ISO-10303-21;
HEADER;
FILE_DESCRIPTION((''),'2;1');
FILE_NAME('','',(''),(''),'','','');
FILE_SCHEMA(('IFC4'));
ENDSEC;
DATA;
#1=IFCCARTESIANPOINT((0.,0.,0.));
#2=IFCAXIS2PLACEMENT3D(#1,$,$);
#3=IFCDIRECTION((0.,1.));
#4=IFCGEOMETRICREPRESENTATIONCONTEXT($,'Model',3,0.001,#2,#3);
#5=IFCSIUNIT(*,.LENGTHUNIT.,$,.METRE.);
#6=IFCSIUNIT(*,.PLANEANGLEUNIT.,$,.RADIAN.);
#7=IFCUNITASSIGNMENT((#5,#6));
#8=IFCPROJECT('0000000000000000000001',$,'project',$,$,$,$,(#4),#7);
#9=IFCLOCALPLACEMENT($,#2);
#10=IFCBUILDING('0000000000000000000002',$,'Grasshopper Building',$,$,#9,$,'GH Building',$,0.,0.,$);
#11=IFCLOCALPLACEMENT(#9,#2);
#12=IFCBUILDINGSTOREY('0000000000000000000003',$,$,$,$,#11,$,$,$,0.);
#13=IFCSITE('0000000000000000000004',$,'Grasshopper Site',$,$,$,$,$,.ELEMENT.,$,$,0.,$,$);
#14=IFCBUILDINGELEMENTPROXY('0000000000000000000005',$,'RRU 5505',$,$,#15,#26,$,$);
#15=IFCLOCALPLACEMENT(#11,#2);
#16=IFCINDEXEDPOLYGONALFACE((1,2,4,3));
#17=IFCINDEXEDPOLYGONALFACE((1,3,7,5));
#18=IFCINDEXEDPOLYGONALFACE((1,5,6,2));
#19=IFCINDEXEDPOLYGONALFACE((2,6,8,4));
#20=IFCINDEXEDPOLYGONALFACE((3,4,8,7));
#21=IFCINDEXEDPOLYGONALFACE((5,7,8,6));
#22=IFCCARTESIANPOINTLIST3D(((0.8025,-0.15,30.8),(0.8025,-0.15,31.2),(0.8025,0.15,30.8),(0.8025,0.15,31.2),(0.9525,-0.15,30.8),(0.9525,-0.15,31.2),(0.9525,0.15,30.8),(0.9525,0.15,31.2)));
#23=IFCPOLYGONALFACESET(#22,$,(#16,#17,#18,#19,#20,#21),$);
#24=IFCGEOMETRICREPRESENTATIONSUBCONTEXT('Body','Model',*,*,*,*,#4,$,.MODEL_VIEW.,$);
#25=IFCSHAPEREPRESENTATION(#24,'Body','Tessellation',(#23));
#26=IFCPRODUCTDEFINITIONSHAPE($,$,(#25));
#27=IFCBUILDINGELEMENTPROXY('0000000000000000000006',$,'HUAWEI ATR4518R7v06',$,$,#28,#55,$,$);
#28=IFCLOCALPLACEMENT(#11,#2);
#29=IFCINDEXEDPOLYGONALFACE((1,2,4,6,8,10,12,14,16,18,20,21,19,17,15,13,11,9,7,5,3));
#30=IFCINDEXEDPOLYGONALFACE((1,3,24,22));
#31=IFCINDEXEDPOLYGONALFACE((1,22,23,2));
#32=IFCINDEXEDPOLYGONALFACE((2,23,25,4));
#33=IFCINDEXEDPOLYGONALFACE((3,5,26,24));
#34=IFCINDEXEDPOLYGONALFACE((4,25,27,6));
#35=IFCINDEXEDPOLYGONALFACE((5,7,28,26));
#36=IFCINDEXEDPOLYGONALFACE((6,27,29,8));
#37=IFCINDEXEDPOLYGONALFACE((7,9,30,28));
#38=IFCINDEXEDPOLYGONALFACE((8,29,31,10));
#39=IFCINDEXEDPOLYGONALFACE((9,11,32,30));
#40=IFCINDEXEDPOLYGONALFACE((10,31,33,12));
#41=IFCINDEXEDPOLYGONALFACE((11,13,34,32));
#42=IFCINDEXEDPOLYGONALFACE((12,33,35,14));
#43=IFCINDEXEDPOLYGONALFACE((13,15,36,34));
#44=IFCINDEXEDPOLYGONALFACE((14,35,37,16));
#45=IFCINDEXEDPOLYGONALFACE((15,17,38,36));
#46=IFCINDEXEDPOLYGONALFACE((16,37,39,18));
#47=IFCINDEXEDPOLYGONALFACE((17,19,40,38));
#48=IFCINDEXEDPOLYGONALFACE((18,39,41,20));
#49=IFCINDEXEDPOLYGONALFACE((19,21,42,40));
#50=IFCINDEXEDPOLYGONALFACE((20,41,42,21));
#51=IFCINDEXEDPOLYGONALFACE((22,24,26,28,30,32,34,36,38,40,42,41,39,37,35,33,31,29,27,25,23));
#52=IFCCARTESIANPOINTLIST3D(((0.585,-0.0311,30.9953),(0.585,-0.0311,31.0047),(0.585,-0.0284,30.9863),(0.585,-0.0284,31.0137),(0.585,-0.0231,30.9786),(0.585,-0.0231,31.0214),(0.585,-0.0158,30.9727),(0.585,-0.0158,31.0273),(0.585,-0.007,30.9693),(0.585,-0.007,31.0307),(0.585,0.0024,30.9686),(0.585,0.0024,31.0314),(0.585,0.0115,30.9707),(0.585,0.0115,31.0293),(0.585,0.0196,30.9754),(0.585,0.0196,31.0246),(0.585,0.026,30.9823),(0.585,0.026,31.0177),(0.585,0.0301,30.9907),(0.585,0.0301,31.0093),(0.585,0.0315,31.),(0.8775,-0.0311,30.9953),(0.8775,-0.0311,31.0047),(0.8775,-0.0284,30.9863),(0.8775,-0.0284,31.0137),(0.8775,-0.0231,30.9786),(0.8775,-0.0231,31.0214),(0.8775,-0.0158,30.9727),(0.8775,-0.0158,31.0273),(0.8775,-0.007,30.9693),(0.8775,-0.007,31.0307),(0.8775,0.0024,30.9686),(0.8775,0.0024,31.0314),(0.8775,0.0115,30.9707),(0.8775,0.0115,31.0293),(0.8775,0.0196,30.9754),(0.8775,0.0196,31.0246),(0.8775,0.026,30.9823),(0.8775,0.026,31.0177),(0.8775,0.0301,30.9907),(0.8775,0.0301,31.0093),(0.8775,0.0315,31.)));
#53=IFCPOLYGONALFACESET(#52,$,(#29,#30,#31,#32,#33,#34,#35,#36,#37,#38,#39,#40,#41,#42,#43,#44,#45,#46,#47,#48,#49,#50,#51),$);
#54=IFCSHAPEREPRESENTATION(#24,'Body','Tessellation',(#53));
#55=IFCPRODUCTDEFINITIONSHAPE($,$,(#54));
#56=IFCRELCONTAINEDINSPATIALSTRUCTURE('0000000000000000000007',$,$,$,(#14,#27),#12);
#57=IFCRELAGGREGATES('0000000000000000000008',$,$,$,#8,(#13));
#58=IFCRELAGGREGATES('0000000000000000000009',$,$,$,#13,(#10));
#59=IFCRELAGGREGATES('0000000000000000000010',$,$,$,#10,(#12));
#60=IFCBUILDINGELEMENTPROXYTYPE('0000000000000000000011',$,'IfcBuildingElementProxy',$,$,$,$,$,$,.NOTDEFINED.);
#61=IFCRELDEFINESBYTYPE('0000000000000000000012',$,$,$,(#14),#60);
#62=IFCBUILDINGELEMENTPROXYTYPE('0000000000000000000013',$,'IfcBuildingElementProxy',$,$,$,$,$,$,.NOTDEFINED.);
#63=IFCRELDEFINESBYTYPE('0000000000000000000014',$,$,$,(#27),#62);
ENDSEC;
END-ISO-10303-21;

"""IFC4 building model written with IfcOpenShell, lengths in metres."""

from ifc_helpers import new_model, si_unit, direction, frame, frame_2d, origin, place, context, subcontext, project, spatial, rectangle, circle, extrude, source, transform, mapped, type_object, type_shapes, element, save


model = new_model("IFC4")

# Units and contexts
model_context = context("Model", 3, precision=0.001, world=origin(), true_north=direction((0.0, 1.0)))
body_context = subcontext(model_context, "Body", "Model", "MODEL_VIEW")
ifc_project = project(units=[si_unit("LENGTHUNIT", "METRE"), si_unit("PLANEANGLEUNIT", "RADIAN")], contexts=[model_context])

# Site, building, storey
site = spatial("IfcSite", under=ifc_project, Name="Grasshopper Site", CompositionType="ELEMENT", RefElevation=0.0)
building_placement = place(None, origin())
building = spatial("IfcBuilding", under=site, at=building_placement, Name="Grasshopper Building", LongName="GH Building", ElevationOfRefHeight=0.0, ElevationOfTerrain=0.0)
storey_placement = place(building_placement, origin())
storey = spatial("IfcBuildingStorey", under=building, at=storey_placement, Elevation=0.0)

# Building element proxies
building_element_proxy_type_1 = type_object("IfcBuildingElementProxyType", Name="IfcBuildingElementProxy", PredefinedType="NOTDEFINED")
shared_shape_1 = source(origin(), body_context, "Body", "SweptSolid", [
    extrude(rectangle(XDim=0.4, YDim=0.3, at=frame_2d((0.0, 0.0), x_axis=(0.0, 1.0))), frame((0.9525, 0.0, 31.0), z_axis=(-1.0, 0.0, 0.0), x_axis=(0.0, 1.0, 0.0)), (0.0, 0.0, 1.0), 0.15),
])
type_shapes(building_element_proxy_type_1, [shared_shape_1])
for number, where, name in (
    (1, (0.0, 0.0, 0.0), "RRU 5505"),
):
    element("IfcBuildingElementProxy", number, at=place(storey_placement, frame(where)), inside=storey, type_object=building_element_proxy_type_1, Name=name, context=body_context, shape_type="MappedRepresentation", body=[
        mapped(shared_shape_1, transform((0.0, 0.0, 0.0), scale=1.0)),
    ])
building_element_proxy_type_2 = type_object("IfcBuildingElementProxyType", Name="IfcBuildingElementProxy", PredefinedType="NOTDEFINED")
shared_shape_2 = source(origin(), body_context, "Body", "SweptSolid", [
    extrude(circle(Radius=0.0315), frame((0.585, 0.0, 31.0), z_axis=(1.0, 0.0, 0.0), x_axis=(0.0, 1.0, 0.0)), (0.0, 0.0, 1.0), 0.2925),
])
type_shapes(building_element_proxy_type_2, [shared_shape_2])
for number, where, name in (
    (2, (0.0, 0.0, 0.0), "HUAWEI ATR4518R7v06"),
):
    element("IfcBuildingElementProxy", number, at=place(storey_placement, frame(where)), inside=storey, type_object=building_element_proxy_type_2, Name=name, context=body_context, shape_type="MappedRepresentation", body=[
        mapped(shared_shape_2, transform((0.0, 0.0, 0.0), scale=1.0)),
    ])

save(model, "model.ifc")
